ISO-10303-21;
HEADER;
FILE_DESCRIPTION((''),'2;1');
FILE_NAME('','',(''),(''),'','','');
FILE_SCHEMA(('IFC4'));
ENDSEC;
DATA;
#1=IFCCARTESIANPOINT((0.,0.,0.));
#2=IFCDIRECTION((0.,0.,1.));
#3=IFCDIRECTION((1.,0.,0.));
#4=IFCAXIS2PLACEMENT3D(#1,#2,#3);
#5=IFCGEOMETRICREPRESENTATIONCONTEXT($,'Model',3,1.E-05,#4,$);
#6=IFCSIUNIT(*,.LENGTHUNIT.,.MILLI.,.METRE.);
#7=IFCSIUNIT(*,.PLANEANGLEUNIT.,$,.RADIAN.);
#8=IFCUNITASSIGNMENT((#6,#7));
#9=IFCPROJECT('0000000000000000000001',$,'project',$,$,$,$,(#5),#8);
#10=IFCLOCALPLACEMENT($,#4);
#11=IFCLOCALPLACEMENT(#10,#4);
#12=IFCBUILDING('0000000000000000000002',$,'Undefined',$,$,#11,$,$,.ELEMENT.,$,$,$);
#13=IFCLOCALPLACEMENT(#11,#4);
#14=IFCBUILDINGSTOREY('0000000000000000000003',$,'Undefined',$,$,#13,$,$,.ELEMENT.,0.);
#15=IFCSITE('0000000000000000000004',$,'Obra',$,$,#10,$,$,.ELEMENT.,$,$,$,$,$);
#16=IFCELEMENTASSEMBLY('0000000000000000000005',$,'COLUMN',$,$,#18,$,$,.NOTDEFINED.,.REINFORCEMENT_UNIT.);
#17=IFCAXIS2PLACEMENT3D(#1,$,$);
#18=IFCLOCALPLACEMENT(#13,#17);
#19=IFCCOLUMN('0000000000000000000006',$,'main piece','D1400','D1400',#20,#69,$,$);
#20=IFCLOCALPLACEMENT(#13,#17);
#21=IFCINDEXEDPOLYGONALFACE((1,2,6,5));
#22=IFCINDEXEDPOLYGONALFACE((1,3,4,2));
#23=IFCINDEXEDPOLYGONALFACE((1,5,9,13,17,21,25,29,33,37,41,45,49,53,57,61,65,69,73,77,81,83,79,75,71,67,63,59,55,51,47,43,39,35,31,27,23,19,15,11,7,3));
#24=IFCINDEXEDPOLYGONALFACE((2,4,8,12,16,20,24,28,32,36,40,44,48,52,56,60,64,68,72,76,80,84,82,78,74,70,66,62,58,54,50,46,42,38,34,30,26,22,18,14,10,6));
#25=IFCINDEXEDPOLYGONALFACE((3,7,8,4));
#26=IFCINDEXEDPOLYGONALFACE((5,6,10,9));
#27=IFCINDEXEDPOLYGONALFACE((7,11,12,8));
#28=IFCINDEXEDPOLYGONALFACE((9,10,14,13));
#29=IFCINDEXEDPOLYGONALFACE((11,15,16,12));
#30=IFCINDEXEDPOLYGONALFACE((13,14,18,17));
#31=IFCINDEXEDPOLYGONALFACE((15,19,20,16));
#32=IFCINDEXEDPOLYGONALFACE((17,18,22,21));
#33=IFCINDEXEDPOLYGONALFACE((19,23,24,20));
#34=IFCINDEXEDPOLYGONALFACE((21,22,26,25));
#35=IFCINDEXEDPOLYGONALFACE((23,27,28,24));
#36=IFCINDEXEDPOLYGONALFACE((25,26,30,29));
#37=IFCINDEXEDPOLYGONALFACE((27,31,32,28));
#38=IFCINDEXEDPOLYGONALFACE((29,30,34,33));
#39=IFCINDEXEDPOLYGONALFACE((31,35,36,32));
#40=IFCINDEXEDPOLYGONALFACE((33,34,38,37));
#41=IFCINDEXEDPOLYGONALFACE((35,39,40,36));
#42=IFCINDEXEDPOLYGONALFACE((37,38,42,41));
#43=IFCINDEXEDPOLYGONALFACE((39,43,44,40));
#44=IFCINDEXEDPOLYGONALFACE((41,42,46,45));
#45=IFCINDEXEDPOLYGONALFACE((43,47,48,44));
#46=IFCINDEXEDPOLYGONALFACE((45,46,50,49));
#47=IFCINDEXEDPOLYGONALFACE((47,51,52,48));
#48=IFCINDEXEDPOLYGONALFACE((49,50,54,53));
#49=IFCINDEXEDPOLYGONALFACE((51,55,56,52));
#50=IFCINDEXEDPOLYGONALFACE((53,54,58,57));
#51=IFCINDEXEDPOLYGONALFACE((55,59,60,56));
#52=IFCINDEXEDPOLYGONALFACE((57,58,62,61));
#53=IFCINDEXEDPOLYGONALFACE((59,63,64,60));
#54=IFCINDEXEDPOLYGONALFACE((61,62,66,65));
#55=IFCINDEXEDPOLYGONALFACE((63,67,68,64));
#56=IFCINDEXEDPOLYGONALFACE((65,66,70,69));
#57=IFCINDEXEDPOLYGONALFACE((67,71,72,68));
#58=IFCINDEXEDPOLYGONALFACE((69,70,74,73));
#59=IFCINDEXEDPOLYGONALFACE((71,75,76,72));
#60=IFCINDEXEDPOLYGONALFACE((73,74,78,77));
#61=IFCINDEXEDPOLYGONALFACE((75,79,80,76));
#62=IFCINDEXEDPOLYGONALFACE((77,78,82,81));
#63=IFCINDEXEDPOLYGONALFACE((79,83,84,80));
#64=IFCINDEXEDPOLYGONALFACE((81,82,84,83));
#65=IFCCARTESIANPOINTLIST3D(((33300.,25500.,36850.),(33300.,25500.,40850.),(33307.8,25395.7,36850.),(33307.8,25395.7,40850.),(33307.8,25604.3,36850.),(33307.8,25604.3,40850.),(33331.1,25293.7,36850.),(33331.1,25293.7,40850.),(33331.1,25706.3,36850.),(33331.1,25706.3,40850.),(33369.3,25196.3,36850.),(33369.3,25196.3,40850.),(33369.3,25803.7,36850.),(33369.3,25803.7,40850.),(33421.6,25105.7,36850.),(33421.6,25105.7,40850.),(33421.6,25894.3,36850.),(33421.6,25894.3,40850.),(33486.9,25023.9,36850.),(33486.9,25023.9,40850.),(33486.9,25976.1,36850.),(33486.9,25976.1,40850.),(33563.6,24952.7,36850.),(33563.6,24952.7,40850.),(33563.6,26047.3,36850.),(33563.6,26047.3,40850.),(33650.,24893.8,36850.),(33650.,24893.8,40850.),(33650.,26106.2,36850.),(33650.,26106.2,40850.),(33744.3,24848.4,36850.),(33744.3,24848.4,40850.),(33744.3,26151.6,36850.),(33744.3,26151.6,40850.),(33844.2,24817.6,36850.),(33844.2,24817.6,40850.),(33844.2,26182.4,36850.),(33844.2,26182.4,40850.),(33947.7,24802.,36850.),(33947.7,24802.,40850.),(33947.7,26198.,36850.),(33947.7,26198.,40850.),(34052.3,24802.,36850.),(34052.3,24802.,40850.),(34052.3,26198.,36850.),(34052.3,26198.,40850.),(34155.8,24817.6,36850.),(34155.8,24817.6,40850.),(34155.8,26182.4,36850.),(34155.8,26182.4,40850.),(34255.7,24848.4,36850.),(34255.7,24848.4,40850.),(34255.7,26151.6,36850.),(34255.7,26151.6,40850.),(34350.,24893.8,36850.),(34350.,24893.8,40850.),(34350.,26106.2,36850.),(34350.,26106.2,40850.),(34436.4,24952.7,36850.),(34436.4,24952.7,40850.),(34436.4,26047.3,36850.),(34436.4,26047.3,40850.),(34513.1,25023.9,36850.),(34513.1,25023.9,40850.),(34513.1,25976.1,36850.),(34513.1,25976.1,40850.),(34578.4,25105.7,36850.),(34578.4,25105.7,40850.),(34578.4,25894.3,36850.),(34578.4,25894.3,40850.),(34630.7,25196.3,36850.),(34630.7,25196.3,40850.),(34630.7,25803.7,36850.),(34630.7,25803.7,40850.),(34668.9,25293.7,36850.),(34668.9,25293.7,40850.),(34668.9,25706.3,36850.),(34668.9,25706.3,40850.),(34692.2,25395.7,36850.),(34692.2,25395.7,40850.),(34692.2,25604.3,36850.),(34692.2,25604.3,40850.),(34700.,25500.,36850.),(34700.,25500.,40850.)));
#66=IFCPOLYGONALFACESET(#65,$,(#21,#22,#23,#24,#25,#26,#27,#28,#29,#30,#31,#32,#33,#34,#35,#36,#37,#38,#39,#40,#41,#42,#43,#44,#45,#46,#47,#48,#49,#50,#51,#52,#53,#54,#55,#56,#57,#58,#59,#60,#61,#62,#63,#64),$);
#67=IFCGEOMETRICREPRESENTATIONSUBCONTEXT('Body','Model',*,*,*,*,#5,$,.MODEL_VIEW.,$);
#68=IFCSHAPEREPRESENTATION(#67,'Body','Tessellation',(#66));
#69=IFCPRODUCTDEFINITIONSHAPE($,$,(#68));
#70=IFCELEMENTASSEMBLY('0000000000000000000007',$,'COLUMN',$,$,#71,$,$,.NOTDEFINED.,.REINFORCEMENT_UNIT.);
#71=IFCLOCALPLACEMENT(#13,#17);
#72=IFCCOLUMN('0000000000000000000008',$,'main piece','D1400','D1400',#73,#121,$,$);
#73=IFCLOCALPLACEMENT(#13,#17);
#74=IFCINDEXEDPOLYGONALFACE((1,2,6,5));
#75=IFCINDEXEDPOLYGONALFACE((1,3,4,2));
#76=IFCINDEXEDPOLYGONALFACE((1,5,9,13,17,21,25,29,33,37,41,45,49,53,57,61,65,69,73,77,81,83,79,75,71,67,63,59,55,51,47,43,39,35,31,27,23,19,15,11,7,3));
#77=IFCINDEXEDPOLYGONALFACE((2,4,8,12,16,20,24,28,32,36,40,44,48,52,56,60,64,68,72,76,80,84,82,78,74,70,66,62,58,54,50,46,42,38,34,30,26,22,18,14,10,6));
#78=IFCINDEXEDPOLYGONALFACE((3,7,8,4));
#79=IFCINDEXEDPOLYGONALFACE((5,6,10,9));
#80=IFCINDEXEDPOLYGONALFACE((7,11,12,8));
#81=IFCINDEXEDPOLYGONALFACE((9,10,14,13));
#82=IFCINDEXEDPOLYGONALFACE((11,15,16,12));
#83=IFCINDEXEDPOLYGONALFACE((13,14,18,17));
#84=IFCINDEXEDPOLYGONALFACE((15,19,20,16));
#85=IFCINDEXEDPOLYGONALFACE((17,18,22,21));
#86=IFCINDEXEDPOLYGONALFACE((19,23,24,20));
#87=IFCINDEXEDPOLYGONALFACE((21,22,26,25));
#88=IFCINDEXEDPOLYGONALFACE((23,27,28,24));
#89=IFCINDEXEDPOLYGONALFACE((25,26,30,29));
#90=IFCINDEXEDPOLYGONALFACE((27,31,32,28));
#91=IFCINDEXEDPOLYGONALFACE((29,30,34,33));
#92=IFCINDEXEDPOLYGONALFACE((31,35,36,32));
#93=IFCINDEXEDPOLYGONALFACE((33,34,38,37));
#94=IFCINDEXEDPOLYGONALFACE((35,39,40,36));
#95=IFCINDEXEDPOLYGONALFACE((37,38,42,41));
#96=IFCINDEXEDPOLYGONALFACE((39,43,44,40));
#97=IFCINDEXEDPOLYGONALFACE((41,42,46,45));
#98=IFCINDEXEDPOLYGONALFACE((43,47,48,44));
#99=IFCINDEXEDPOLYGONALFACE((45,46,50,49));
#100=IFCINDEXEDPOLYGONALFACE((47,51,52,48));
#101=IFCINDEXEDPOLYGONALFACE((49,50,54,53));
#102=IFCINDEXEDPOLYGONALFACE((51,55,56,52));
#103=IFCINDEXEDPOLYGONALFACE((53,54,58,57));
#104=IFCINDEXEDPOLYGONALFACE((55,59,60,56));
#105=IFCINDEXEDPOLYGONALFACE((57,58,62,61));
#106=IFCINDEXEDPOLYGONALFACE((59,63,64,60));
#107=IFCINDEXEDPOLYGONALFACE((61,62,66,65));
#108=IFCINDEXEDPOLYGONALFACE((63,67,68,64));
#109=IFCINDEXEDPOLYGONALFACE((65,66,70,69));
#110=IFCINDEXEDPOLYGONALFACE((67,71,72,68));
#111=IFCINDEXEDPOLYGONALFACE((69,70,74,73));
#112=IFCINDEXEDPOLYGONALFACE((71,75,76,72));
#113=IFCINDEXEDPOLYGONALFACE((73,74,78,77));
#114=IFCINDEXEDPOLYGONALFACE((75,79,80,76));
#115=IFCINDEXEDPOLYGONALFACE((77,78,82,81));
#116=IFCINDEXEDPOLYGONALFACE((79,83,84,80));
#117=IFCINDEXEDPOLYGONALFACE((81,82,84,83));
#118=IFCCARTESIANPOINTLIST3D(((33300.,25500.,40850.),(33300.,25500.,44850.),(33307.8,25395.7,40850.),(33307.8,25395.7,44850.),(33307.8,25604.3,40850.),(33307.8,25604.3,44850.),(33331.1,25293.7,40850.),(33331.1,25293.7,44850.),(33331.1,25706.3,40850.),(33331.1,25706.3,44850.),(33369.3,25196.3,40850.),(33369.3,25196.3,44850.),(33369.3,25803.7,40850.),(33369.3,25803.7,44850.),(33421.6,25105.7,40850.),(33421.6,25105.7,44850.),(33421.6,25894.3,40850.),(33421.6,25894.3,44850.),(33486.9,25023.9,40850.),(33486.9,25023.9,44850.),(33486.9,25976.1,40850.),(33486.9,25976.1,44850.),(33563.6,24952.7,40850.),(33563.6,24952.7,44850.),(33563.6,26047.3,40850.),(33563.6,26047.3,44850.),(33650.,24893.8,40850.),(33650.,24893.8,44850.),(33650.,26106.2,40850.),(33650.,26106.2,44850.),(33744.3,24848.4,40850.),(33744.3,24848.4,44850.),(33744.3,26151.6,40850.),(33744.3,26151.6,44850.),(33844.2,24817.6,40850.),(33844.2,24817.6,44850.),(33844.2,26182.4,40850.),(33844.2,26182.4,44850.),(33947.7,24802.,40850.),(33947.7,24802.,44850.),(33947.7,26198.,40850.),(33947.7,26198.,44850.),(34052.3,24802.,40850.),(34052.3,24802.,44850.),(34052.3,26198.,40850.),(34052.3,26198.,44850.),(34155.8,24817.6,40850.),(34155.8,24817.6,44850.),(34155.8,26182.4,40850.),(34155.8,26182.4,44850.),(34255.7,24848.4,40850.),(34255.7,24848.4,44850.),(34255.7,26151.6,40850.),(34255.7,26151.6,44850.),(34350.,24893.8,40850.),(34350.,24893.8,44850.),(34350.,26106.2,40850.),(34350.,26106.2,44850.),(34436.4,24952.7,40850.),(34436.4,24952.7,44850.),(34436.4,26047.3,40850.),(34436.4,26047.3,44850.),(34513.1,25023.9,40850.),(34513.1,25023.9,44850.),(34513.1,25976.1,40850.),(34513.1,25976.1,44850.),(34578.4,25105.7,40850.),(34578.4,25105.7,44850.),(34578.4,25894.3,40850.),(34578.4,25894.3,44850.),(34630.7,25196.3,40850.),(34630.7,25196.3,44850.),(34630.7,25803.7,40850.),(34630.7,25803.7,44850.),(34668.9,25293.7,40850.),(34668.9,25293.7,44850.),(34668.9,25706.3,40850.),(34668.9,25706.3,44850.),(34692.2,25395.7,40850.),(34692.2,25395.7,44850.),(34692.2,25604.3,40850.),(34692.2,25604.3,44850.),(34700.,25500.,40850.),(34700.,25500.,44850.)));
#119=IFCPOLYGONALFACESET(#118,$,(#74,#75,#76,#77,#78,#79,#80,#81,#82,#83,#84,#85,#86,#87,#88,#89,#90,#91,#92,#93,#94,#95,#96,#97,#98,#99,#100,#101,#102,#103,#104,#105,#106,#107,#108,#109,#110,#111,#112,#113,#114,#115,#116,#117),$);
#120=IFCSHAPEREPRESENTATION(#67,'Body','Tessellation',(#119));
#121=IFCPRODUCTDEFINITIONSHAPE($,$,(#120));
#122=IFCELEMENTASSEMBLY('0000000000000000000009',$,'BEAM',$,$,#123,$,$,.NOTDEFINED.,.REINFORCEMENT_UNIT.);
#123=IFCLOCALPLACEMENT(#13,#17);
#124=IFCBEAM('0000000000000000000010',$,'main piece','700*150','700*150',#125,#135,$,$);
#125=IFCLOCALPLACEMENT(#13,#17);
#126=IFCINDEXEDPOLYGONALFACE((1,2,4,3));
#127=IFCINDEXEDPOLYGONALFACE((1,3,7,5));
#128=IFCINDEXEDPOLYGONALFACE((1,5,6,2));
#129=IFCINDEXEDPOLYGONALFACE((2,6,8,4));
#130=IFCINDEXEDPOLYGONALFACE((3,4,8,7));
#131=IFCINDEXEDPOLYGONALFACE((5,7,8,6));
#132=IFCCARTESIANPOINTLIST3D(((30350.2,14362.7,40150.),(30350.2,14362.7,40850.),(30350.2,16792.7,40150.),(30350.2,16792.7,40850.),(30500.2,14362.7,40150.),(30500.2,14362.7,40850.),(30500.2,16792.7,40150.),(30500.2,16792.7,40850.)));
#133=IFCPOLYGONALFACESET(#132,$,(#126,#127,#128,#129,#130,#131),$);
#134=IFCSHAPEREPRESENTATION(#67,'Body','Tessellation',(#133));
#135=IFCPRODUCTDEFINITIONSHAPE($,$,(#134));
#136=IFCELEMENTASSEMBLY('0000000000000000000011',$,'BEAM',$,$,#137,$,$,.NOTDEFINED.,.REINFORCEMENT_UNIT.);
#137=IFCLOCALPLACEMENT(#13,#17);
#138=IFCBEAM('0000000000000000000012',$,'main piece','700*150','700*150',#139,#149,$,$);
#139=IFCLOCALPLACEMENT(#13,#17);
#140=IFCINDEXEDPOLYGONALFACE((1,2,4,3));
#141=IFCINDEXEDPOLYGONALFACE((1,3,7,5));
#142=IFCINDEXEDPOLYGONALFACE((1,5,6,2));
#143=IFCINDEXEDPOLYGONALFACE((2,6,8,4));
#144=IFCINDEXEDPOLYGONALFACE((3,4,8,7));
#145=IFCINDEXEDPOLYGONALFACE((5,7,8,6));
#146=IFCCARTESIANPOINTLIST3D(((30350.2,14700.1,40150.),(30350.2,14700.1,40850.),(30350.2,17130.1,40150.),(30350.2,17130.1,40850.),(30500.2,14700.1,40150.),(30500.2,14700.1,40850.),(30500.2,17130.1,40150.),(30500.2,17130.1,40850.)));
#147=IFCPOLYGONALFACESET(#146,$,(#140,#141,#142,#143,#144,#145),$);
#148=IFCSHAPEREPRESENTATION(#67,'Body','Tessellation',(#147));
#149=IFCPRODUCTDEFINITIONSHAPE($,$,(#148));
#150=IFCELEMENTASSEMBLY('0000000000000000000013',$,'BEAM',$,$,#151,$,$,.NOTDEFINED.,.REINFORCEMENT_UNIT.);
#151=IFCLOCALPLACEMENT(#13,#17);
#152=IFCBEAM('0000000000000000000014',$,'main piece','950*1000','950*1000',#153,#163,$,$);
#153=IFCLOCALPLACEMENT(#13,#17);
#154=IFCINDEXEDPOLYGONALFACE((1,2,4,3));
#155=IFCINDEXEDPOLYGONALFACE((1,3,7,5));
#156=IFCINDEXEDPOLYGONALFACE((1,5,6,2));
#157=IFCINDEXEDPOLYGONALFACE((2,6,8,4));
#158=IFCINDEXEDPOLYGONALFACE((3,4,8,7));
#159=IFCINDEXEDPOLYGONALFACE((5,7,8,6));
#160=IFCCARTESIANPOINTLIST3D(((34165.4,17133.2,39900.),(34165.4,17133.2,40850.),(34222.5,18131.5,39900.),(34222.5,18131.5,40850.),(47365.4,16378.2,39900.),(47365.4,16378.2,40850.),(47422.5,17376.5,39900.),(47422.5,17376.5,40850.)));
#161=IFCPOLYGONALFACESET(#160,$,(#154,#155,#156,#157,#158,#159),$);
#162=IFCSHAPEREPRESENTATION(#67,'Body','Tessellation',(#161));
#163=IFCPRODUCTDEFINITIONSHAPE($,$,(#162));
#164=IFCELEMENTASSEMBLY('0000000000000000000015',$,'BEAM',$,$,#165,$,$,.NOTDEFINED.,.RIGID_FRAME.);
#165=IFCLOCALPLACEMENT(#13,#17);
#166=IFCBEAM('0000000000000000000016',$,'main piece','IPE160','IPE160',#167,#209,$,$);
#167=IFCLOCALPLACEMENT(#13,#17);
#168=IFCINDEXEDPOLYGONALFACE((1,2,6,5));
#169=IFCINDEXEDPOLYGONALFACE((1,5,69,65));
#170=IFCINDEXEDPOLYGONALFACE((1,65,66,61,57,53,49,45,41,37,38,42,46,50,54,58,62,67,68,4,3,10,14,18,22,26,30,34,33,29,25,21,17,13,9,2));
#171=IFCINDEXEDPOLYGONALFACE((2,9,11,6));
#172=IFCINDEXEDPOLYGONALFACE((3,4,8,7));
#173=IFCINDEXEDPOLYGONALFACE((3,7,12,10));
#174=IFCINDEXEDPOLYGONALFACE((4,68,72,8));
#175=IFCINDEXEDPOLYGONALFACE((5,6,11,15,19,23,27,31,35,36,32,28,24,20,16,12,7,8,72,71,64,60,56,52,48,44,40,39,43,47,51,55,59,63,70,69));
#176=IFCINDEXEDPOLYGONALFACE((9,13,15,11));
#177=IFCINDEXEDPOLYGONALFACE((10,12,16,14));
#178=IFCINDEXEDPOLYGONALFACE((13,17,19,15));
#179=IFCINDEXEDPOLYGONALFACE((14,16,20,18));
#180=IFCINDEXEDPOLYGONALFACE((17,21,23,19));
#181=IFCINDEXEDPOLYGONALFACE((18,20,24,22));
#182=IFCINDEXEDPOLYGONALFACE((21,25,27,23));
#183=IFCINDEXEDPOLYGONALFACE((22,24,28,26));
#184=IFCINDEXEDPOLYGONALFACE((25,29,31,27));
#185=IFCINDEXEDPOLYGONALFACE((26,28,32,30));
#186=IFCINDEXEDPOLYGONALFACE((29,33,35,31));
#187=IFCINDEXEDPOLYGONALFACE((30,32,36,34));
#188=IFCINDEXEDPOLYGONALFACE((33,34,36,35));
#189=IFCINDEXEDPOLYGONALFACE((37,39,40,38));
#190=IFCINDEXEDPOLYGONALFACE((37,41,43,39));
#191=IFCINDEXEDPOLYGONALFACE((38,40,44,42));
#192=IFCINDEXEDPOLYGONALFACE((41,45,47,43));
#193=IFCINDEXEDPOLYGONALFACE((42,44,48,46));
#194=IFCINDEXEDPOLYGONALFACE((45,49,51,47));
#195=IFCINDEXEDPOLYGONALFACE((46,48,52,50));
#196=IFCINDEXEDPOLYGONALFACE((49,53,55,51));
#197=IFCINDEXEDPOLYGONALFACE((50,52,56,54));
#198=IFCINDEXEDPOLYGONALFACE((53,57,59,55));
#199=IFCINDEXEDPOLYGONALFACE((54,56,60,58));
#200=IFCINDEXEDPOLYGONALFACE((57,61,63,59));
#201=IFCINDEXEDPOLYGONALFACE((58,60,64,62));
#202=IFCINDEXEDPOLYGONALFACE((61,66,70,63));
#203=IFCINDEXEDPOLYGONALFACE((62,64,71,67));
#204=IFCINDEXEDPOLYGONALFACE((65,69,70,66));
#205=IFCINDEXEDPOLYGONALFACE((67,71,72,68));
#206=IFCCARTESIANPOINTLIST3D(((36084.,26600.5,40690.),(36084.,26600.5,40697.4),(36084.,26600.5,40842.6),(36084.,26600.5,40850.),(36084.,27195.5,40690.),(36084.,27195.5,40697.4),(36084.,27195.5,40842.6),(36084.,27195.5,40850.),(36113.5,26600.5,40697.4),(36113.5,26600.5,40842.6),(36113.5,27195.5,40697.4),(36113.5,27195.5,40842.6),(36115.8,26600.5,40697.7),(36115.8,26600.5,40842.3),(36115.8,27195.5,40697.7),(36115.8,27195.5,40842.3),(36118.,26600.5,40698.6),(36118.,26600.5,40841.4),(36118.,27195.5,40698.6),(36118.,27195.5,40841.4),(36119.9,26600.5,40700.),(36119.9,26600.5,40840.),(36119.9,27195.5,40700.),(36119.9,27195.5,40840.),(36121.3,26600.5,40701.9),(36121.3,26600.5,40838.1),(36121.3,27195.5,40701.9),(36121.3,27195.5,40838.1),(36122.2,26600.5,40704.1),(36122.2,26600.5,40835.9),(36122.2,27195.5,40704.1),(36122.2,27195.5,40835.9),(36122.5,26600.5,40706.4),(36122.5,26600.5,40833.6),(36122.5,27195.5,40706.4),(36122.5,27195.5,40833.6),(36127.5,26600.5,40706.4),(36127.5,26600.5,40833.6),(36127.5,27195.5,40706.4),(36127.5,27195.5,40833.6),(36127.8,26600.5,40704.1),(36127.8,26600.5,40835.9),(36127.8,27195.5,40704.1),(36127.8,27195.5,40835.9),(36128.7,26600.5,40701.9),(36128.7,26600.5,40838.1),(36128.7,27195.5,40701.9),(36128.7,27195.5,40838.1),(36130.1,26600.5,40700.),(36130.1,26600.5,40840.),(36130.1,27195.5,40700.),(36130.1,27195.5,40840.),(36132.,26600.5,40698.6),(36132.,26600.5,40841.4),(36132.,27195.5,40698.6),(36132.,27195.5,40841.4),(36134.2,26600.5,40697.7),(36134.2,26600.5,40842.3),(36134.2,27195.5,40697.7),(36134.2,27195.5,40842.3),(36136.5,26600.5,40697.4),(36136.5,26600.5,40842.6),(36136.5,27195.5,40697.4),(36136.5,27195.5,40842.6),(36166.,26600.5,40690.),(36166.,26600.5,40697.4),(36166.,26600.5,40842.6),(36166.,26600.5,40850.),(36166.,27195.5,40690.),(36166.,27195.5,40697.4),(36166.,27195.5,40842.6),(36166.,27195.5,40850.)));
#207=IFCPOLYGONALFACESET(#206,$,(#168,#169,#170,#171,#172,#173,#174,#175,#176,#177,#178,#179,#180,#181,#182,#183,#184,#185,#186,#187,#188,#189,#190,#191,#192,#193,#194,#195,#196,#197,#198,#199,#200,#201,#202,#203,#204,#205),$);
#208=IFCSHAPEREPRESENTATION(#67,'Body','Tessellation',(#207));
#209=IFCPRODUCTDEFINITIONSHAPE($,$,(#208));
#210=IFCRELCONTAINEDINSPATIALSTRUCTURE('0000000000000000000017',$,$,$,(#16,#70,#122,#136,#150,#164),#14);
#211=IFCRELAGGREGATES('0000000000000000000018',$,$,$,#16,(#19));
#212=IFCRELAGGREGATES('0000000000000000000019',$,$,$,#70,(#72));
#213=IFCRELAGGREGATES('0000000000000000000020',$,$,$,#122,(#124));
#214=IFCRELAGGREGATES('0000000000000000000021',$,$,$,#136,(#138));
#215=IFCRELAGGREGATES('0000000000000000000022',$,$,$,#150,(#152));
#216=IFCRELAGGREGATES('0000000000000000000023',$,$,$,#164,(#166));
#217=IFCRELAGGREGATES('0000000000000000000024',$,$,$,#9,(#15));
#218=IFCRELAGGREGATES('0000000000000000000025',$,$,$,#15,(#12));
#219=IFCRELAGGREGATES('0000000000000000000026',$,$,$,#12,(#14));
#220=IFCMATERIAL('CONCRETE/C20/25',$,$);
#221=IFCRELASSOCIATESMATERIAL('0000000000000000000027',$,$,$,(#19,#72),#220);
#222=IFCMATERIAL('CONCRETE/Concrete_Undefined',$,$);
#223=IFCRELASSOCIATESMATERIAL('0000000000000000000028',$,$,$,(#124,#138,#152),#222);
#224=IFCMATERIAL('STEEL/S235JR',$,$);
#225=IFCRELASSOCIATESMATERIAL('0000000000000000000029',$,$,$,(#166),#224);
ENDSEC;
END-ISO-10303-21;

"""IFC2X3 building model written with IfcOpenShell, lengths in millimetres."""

from ifc_helpers import new_model, si_unit, frame, origin_with_axes, origin_2d_with_axis, place, context, subcontext, project, spatial, rectangle, circle, i_section, extrude, material, element, aggregate, save


model = new_model("IFC2X3")

# Units and contexts
model_context = context("Model", 3, precision=1e-05, world=origin_with_axes())
body_context = subcontext(model_context, "Body", "Model", "MODEL_VIEW")
ifc_project = project(units=[si_unit("LENGTHUNIT", "METRE", prefix="MILLI"), si_unit("PLANEANGLEUNIT", "RADIAN")], contexts=[model_context])

# Site, building, storey
site_placement = place(None, origin_with_axes())
site = spatial("IfcSite", under=ifc_project, at=site_placement, Name="Obra", CompositionType="ELEMENT")
building_placement = place(site_placement, origin_with_axes())
building = spatial("IfcBuilding", under=site, at=building_placement, Name="Undefined", CompositionType="ELEMENT")
storey_placement = place(building_placement, origin_with_axes())
storey = spatial("IfcBuildingStorey", under=building, at=storey_placement, Name="Undefined", CompositionType="ELEMENT", Elevation=0.0)

# Element assemblies, columns
assembly_1_placement = place(storey_placement, origin_with_axes())
assembly_1 = element("IfcElementAssembly", 1, at=assembly_1_placement, inside=storey, Name="COLUMN", AssemblyPlace="NOTDEFINED", PredefinedType="REINFORCEMENT_UNIT")
ifc_material_1 = material(Name="CONCRETE/C20/25")
column_1_placement = place(assembly_1_placement, frame((34000.0, 25500.0, 36850.0), z_axis=(0.0, 0.0, 1.0), x_axis=(0.0, 1.0, 0.0)))
column_1 = element("IfcColumn", 2, at=column_1_placement, material=ifc_material_1, Name="main piece", Description="D1400", ObjectType="D1400", context=body_context, shape_type="SweptSolid", body=[
    extrude(circle(Radius=700.0, at=origin_2d_with_axis()), frame((0.0, 0.0, 4000.0), z_axis=(0.0, 0.0, -1.0), x_axis=(0.0, 1.0, 0.0)), (0.0, 0.0, 1.0), 4000.0),
])
aggregate(assembly_1, [column_1])
assembly_2_placement = place(storey_placement, origin_with_axes())
assembly_2 = element("IfcElementAssembly", 3, at=assembly_2_placement, inside=storey, Name="COLUMN", AssemblyPlace="NOTDEFINED", PredefinedType="REINFORCEMENT_UNIT")
column_2_placement = place(assembly_2_placement, frame((34000.0, 25500.0, 40850.0), z_axis=(0.0, 0.0, 1.0), x_axis=(0.0, 1.0, 0.0)))
column_2 = element("IfcColumn", 4, at=column_2_placement, material=ifc_material_1, Name="main piece", Description="D1400", ObjectType="D1400", context=body_context, shape_type="SweptSolid", body=[
    extrude(circle(Radius=700.0, at=origin_2d_with_axis()), frame((0.0, 0.0, 4000.0), z_axis=(0.0, 0.0, -1.0), x_axis=(0.0, 1.0, 0.0)), (0.0, 0.0, 1.0), 4000.0),
])
aggregate(assembly_2, [column_2])

# Element assemblies, beams
assembly_3_placement = place(storey_placement, origin_with_axes())
assembly_3 = element("IfcElementAssembly", 5, at=assembly_3_placement, inside=storey, Name="BEAM", AssemblyPlace="NOTDEFINED", PredefinedType="REINFORCEMENT_UNIT")
ifc_material_2 = material(Name="CONCRETE/Concrete_Undefined")
beam_1_placement = place(assembly_3_placement, frame((30425.2, 14362.7, 40500.0), z_axis=(0.0, 0.0, 1.0), x_axis=(0.0, 1.0, 0.0)))
beam_1 = element("IfcBeam", 6, at=beam_1_placement, material=ifc_material_2, Name="main piece", Description="700*150", ObjectType="700*150", context=body_context, shape_type="SweptSolid", body=[
    extrude(rectangle(XDim=150.0, YDim=700.0, at=origin_2d_with_axis()), frame((2430.0, 0.0, 0.0), z_axis=(-1.0, 0.0, 0.0), x_axis=(0.0, -1.0, 0.0)), (0.0, 0.0, 1.0), 2430.0),
])
aggregate(assembly_3, [beam_1])
assembly_4_placement = place(storey_placement, origin_with_axes())
assembly_4 = element("IfcElementAssembly", 7, at=assembly_4_placement, inside=storey, Name="BEAM", AssemblyPlace="NOTDEFINED", PredefinedType="REINFORCEMENT_UNIT")
beam_2_placement = place(assembly_4_placement, frame((30425.2, 14700.1, 40500.0), z_axis=(0.0, 0.0, 1.0), x_axis=(0.0, 1.0, 0.0)))
beam_2 = element("IfcBeam", 8, at=beam_2_placement, material=ifc_material_2, Name="main piece", Description="700*150", ObjectType="700*150", context=body_context, shape_type="SweptSolid", body=[
    extrude(rectangle(XDim=150.0, YDim=700.0, at=origin_2d_with_axis()), frame((2430.0, 0.0, 0.0), z_axis=(-1.0, 0.0, 0.0), x_axis=(0.0, -1.0, 0.0)), (0.0, 0.0, 1.0), 2430.0),
])
aggregate(assembly_4, [beam_2])
assembly_5_placement = place(storey_placement, origin_with_axes())
assembly_5 = element("IfcElementAssembly", 9, at=assembly_5_placement, inside=storey, Name="BEAM", AssemblyPlace="NOTDEFINED", PredefinedType="REINFORCEMENT_UNIT")
beam_3_placement = place(assembly_5_placement, frame((34194.0, 17632.3, 40375.0), z_axis=(0.0, 0.0, 1.0), x_axis=(0.998368, -0.057102, 0.0)))
beam_3 = element("IfcBeam", 10, at=beam_3_placement, material=ifc_material_2, Name="main piece", Description="950*1000", ObjectType="950*1000", context=body_context, shape_type="SweptSolid", body=[
    extrude(rectangle(XDim=1000.0, YDim=950.0, at=origin_2d_with_axis()), frame((13221.6, 0.0, 0.0), z_axis=(-1.0, 0.0, 0.0), x_axis=(0.0, -1.0, 0.0)), (0.0, 0.0, 1.0), 13221.6),
])
aggregate(assembly_5, [beam_3])
assembly_6_placement = place(storey_placement, origin_with_axes())
assembly_6 = element("IfcElementAssembly", 11, at=assembly_6_placement, inside=storey, Name="BEAM", AssemblyPlace="NOTDEFINED", PredefinedType="RIGID_FRAME")
ifc_material_3 = material(Name="STEEL/S235JR")
beam_4_placement = place(assembly_6_placement, frame((36125.0, 26600.5, 40770.0), z_axis=(0.0, 0.0, 1.0), x_axis=(0.0, 1.0, 0.0)))
beam_4 = element("IfcBeam", 12, at=beam_4_placement, material=ifc_material_3, Name="main piece", Description="IPE160", ObjectType="IPE160", context=body_context, shape_type="SweptSolid", body=[
    extrude(i_section(OverallWidth=82.0, OverallDepth=160.0, WebThickness=5.0, FlangeThickness=7.4, FilletRadius=9.0, at=origin_2d_with_axis()), frame((595.0, 0.0, 0.0), z_axis=(-1.0, 0.0, 0.0), x_axis=(0.0, -1.0, 0.0)), (0.0, 0.0, 1.0), 595.0),
])
aggregate(assembly_6, [beam_4])

save(model, "model.ifc")
